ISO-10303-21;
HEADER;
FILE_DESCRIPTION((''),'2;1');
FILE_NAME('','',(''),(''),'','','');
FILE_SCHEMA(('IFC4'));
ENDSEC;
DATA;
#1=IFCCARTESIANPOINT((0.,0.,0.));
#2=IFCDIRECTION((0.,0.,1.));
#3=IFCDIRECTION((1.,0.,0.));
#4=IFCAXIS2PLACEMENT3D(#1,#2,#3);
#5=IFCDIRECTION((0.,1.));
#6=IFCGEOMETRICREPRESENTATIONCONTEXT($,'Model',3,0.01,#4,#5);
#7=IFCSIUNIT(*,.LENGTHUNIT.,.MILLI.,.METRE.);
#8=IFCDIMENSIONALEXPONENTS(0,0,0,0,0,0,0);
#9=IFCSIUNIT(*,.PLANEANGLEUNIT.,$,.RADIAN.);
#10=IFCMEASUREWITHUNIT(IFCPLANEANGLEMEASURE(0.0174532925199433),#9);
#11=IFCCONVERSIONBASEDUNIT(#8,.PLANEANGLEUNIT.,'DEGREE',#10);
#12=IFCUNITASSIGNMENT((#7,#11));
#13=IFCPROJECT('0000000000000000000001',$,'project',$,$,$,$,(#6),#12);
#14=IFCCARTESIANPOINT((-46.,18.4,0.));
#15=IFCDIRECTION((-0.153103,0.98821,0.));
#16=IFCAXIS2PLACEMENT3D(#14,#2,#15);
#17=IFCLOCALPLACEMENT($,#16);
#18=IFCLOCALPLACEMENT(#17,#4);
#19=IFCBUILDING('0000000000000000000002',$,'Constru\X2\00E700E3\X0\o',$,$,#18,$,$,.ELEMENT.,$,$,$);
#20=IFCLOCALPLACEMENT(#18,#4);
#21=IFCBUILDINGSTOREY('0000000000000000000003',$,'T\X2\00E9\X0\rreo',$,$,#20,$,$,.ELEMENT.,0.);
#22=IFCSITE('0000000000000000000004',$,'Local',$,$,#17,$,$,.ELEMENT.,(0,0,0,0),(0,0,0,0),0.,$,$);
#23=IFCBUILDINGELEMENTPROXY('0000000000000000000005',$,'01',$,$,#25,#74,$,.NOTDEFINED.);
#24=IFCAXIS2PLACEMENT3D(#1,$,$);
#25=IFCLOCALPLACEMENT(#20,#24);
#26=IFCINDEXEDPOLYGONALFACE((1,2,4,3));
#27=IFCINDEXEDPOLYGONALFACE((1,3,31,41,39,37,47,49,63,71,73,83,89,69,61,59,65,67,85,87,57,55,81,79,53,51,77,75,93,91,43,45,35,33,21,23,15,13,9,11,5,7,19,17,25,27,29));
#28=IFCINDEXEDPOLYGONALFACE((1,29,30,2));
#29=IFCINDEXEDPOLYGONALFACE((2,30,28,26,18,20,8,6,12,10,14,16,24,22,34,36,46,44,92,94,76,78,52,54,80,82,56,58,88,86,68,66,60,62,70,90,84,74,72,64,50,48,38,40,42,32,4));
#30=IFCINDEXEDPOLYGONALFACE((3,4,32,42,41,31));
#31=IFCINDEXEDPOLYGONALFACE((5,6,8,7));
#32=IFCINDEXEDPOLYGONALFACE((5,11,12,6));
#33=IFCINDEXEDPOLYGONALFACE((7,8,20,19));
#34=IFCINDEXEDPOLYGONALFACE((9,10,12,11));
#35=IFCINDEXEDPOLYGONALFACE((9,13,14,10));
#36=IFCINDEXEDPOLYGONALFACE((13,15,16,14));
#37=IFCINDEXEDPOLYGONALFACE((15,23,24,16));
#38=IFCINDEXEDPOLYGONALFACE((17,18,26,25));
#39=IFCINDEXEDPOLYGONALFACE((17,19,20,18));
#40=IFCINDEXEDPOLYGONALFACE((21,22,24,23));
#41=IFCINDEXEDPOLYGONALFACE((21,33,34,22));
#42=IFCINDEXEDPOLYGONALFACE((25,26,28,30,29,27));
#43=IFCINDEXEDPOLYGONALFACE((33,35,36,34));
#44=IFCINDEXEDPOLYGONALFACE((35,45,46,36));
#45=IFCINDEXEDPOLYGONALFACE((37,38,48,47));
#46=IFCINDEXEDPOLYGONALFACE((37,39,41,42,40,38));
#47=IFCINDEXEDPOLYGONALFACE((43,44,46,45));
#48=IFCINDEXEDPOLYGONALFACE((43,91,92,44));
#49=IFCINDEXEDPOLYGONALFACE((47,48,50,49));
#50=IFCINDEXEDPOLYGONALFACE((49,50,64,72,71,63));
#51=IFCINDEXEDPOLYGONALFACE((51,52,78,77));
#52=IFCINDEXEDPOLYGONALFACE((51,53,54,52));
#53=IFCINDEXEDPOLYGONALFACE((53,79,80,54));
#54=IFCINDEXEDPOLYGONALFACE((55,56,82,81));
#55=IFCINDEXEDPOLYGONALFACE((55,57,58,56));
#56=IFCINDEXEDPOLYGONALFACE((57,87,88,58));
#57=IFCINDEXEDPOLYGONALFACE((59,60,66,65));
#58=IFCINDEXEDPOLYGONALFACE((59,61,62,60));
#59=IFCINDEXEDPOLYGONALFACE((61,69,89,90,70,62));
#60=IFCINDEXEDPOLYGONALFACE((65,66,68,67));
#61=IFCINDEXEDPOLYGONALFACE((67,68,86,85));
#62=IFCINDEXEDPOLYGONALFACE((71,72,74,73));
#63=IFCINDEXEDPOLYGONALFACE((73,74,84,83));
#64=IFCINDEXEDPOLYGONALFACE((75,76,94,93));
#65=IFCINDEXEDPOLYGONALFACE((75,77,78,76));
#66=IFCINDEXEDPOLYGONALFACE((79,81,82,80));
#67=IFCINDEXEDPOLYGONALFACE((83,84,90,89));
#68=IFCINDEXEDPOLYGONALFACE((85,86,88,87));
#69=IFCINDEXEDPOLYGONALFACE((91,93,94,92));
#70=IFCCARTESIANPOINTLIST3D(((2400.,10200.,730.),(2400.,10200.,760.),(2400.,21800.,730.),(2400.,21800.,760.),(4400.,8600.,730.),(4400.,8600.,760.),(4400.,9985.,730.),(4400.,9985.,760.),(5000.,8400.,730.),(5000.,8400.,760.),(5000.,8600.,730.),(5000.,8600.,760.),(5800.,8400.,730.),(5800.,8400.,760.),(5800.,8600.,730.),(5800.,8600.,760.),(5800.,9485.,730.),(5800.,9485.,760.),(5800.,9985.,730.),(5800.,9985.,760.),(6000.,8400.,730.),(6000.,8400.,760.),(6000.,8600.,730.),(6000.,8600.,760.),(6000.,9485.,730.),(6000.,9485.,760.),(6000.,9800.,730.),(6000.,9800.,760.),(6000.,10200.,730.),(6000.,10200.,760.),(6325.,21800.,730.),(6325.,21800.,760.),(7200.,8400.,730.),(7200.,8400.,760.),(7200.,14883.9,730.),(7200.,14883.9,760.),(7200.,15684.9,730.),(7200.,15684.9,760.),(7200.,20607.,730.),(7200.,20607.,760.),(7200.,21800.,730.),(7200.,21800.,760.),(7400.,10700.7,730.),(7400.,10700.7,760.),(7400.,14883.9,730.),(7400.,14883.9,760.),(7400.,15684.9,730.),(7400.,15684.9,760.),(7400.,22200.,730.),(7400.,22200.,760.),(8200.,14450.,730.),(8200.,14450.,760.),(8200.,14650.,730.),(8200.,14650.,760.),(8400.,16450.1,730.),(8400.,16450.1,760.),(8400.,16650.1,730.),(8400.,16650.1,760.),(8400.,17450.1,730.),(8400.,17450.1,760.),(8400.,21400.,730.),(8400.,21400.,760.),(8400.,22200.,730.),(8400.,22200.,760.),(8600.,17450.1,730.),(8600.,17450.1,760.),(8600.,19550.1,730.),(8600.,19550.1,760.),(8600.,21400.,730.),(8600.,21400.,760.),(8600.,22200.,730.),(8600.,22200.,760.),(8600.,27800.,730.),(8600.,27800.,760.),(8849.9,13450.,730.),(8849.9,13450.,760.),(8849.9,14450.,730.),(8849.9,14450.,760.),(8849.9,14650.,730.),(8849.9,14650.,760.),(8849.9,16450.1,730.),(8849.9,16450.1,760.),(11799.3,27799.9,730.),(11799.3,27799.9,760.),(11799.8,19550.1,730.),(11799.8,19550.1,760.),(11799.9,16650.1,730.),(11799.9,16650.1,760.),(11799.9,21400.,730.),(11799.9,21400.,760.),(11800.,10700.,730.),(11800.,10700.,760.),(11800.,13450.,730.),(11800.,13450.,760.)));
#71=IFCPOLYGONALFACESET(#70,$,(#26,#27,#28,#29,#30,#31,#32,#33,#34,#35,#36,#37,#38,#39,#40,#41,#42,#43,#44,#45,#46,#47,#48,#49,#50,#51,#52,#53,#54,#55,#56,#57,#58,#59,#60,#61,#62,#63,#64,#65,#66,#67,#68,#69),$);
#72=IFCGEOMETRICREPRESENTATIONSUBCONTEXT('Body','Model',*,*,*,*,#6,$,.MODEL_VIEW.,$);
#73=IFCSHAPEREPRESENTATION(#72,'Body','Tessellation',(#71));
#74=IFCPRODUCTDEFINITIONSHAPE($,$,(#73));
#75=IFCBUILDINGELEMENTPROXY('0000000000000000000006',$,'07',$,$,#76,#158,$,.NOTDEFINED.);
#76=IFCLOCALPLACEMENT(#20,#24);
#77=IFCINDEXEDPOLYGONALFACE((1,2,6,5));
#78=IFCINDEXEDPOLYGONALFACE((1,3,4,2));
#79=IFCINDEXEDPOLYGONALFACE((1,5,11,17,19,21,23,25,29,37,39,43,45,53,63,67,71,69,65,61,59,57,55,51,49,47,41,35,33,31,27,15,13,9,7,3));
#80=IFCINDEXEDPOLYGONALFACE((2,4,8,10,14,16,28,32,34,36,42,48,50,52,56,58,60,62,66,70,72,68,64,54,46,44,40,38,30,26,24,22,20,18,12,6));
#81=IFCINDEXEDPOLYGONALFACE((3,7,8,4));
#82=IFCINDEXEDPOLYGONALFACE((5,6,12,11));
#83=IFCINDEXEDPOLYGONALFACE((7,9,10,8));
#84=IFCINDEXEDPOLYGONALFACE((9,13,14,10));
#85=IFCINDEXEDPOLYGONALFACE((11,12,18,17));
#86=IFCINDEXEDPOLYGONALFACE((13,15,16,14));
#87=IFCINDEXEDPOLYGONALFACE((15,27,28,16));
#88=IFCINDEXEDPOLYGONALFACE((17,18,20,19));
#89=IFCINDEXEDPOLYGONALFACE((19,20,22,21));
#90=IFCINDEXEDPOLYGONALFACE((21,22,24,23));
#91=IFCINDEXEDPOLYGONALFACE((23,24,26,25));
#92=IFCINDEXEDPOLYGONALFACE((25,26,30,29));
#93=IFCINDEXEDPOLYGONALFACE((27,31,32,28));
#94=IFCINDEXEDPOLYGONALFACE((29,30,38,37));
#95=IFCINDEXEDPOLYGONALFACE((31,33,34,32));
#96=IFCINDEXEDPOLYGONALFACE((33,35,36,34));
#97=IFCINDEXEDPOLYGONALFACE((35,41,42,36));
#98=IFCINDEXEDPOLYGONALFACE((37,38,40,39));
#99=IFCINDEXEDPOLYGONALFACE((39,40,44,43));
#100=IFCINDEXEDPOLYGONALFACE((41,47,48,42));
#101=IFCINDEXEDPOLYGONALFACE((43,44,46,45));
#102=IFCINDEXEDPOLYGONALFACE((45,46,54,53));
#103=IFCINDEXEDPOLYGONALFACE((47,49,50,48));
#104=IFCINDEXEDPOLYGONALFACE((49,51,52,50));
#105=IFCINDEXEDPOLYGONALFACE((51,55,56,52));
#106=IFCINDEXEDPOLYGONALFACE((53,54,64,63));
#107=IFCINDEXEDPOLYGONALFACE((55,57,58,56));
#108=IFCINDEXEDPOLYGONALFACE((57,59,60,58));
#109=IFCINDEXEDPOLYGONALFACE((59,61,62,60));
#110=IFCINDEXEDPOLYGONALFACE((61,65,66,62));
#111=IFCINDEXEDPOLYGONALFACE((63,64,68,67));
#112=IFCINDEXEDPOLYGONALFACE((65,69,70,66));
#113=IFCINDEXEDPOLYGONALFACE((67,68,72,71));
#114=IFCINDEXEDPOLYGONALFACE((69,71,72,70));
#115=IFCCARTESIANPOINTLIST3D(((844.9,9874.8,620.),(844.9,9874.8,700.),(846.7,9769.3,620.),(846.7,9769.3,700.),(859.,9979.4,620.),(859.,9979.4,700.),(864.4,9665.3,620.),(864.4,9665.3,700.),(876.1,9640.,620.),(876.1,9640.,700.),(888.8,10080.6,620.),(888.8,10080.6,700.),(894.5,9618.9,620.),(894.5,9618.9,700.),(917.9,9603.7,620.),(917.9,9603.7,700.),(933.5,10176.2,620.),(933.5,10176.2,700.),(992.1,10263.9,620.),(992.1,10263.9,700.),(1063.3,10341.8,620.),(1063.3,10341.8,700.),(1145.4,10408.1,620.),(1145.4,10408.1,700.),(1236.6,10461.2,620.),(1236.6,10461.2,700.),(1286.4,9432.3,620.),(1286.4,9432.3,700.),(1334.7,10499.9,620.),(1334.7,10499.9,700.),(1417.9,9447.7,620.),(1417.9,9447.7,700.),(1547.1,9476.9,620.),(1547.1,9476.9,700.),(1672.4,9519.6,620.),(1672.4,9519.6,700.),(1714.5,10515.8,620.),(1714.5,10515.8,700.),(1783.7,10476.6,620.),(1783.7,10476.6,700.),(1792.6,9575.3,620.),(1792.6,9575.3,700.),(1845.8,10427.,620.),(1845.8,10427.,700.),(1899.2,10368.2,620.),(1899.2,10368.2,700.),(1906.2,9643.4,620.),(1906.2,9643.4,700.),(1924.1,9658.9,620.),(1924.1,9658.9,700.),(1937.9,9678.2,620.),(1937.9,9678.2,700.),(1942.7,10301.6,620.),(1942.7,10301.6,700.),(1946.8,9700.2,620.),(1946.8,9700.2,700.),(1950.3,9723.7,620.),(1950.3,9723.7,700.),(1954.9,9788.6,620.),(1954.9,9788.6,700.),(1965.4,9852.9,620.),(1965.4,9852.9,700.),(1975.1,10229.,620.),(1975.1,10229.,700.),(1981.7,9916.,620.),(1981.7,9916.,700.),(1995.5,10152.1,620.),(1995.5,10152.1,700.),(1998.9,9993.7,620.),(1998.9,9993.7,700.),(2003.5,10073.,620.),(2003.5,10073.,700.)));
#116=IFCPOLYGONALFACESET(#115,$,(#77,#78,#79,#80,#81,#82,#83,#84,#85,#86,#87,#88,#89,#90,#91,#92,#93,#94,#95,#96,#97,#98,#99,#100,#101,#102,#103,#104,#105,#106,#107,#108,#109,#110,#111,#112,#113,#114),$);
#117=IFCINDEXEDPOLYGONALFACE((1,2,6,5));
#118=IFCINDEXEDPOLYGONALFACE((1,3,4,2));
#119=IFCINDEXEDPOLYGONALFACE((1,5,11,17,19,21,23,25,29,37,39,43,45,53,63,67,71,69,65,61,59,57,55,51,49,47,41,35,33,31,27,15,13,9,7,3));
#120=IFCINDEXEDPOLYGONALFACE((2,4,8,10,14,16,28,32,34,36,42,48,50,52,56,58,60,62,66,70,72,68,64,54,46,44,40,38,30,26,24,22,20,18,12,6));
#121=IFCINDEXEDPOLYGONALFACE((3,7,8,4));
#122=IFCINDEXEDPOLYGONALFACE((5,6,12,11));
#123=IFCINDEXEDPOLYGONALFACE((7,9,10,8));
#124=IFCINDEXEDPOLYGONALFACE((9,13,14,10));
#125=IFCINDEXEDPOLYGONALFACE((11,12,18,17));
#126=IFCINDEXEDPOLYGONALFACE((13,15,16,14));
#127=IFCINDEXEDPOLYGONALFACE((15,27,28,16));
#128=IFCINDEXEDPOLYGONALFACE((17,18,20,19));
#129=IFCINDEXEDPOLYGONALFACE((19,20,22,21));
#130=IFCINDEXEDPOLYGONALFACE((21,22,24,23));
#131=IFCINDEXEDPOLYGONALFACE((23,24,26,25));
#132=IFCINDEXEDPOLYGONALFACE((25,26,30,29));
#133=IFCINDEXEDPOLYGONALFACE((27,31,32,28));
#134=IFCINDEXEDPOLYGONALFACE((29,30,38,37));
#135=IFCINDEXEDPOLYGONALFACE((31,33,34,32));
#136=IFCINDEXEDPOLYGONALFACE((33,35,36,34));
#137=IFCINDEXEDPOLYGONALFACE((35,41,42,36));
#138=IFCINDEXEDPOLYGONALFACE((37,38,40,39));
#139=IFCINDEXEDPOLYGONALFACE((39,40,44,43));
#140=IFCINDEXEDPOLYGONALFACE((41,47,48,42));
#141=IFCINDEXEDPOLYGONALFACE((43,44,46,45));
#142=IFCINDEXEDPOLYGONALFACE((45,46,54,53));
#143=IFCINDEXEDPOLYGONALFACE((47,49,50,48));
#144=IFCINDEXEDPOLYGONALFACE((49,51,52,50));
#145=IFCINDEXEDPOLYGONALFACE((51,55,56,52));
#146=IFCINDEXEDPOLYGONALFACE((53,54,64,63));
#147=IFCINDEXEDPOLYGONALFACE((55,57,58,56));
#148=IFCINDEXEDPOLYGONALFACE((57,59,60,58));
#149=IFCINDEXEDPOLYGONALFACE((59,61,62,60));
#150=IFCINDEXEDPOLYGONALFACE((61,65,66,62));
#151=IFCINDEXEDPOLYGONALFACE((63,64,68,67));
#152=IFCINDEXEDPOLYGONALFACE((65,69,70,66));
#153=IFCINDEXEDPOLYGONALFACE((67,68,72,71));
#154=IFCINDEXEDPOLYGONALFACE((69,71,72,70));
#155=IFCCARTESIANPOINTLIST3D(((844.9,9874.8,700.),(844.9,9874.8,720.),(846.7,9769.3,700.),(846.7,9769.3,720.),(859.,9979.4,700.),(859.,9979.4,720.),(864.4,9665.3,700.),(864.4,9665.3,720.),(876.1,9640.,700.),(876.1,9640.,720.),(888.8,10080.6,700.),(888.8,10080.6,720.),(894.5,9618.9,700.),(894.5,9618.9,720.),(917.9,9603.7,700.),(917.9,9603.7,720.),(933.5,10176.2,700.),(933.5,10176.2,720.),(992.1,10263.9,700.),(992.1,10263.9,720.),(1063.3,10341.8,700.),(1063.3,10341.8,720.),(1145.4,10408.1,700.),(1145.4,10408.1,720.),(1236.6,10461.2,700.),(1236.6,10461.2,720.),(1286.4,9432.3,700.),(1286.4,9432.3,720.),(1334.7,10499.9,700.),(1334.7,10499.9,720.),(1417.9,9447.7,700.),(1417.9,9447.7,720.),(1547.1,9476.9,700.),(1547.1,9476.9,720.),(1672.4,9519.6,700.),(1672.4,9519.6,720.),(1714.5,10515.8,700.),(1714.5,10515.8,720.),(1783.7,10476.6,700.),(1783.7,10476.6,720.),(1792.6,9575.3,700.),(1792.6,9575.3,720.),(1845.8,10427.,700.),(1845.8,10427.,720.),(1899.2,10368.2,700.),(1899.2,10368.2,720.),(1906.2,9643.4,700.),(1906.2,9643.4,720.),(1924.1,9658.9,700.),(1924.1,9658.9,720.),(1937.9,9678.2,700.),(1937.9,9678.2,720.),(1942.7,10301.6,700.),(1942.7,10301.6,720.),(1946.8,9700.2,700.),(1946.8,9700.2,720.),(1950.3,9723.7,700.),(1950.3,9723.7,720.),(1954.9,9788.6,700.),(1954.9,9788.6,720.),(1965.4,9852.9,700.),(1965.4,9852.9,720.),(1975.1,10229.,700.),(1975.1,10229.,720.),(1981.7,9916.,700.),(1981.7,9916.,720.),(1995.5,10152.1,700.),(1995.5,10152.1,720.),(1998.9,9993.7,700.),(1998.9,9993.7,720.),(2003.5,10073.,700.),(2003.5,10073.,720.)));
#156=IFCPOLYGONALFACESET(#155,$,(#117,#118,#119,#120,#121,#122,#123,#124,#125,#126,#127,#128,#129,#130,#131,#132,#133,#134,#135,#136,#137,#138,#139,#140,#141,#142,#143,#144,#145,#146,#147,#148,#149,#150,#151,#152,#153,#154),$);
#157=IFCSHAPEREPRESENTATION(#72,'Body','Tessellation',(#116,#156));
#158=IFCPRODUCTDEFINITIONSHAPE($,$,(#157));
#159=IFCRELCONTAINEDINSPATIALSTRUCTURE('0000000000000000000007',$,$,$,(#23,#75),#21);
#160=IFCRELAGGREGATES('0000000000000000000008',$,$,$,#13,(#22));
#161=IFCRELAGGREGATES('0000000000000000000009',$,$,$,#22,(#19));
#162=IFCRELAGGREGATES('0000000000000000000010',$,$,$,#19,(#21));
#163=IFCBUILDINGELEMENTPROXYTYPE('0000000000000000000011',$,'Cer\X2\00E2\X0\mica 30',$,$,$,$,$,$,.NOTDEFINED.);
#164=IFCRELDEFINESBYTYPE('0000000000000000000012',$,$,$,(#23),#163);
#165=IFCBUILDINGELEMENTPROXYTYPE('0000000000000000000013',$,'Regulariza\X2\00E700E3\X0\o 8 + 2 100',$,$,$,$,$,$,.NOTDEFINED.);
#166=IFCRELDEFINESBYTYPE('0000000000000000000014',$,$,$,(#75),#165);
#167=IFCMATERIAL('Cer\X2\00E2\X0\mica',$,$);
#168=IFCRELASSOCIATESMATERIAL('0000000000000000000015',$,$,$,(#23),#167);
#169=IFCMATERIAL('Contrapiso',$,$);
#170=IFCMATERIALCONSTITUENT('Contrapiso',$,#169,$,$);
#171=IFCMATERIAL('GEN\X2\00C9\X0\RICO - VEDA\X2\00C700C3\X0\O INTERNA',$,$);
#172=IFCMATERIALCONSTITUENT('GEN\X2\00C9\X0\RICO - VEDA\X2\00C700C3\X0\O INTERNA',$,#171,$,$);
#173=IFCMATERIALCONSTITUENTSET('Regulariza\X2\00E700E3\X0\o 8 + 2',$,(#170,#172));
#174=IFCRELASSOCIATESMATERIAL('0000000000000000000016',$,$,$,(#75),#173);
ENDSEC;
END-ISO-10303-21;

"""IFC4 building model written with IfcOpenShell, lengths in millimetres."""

from ifc_helpers import new_model, entity, si_unit, converted_unit, direction, frame, origin_with_axes, place, context, subcontext, project, spatial, line, arc, indexed_curve, outline, extrude, material, constituent, constituent_set, type_object, element, save


model = new_model("IFC4")

# Units and contexts
model_context = context("Model", 3, precision=0.01, world=origin_with_axes(), true_north=direction((0.0, 1.0)))
body_context = subcontext(model_context, "Body", "Model", "MODEL_VIEW")
ifc_project = project(units=[si_unit("LENGTHUNIT", "METRE", prefix="MILLI"), converted_unit("PLANEANGLEUNIT", "DEGREE", entity("IfcPlaneAngleMeasure", 0.0174532925199433), si_unit("PLANEANGLEUNIT", "RADIAN"), dimensions=[0, 0, 0, 0, 0, 0, 0])], contexts=[model_context])

# Site, building, storey
site_placement = place(None, frame((-46.0, 18.4, 0.0), z_axis=(0.0, 0.0, 1.0), x_axis=(-0.153103, 0.98821, 0.0)))
site = spatial("IfcSite", under=ifc_project, at=site_placement, Name="Local", CompositionType="ELEMENT", RefLatitude=(0, 0, 0, 0), RefLongitude=(0, 0, 0, 0), RefElevation=0.0)
building_placement = place(site_placement, origin_with_axes())
building = spatial("IfcBuilding", under=site, at=building_placement, Name="Construção", CompositionType="ELEMENT")
storey_placement = place(building_placement, origin_with_axes())
storey = spatial("IfcBuildingStorey", under=building, at=storey_placement, Name="Térreo", CompositionType="ELEMENT", Elevation=0.0)

# Shared definitions
ifc_material_1 = material(Name="GENÉRICO - VEDAÇÃO INTERNA")

# Building element proxies
ifc_material_2 = material(Name="Cerâmica")
building_element_proxy_type_1 = type_object("IfcBuildingElementProxyType", Name="Cerâmica 30", PredefinedType="NOTDEFINED")
proxy_1_placement = place(storey_placement, frame((2400.0, 10200.0, 760.0), z_axis=(0.0, 0.0, 1.0), x_axis=(1.0, 0.0, 0.0)))
element("IfcBuildingElementProxy", 1, at=proxy_1_placement, inside=storey, type_object=building_element_proxy_type_1, material=ifc_material_2, Name="01", PredefinedType="NOTDEFINED", context=body_context, shape_type="SweptSolid", body=[
    extrude(outline(indexed_curve([(0.0, 0.0), (3600.0, 0.0), (3600.0, -400.0), (3600.0, -715.0), (3400.0, -715.0), (3400.0, -215.0), (2000.0, -215.0), (2000.0, -1600.0), (2600.0, -1600.0), (2600.0, -1800.0), (3400.0, -1800.0), (3400.0, -1600.0), (3600.0, -1600.0), (3600.0, -1800.0), (4800.0, -1800.0), (4800.0, 4683.9), (5000.0, 4683.9), (5000.0, 500.7), (9400.0, 500.0), (9400.0, 3250.0), (6449.9, 3250.0), (6449.9, 4250.0), (5800.0, 4250.0), (5800.0, 4450.0), (6449.9, 4450.0), (6449.9, 6250.0), (6000.0, 6250.0), (6000.0, 6450.0), (9399.9, 6450.0), (9399.8, 9350.0), (6200.0, 9350.0), (6200.0, 7250.0), (6000.0, 7250.0), (6000.0, 11200.0), (6200.0, 11200.0), (9399.9, 11200.0), (9399.3, 17599.9), (6200.0, 17600.0), (6200.0, 12000.0), (6000.0, 12000.0), (5000.0, 12000.0), (5000.0, 5484.9), (4800.0, 5484.9), (4800.0, 10407.0), (4800.0, 11600.0), (3925.0, 11600.0), (0.0, 11600.0)], segments=[line(1, 2, 3, 4, 5, 6, 7, 8, 9, 10, 11, 12, 13, 14, 15, 16, 17, 18, 19, 20, 21, 22, 23, 24, 25, 26, 27, 28, 29, 30, 31, 32, 33, 34, 35, 36, 37, 38, 39, 40, 41, 42, 43, 44, 45, 46, 47, 1)])), frame((0.0, 0.0, -30.0), z_axis=(0.0, 0.0, 1.0), x_axis=(1.0, 0.0, 0.0)), (0.0, 0.0, 1.0), 30.0),
])
ifc_material_3 = material(Name="Contrapiso")
ifc_constituent_1 = constituent(ifc_material_3, Name="Contrapiso")
ifc_constituent_2 = constituent(ifc_material_1, Name="GENÉRICO - VEDAÇÃO INTERNA")
ifc_constituent_set_1 = constituent_set(constituents=[ifc_constituent_1, ifc_constituent_2], Name="Regularização 8 + 2")
building_element_proxy_type_2 = type_object("IfcBuildingElementProxyType", Name="Regularização 8 + 2 100", PredefinedType="NOTDEFINED")
proxy_2_placement = place(storey_placement, frame((1334.7, 10499.9, 720.0), z_axis=(0.0, 0.0, 1.0), x_axis=(1.0, 0.0, 0.0)))
element("IfcBuildingElementProxy", 2, at=proxy_2_placement, inside=storey, type_object=building_element_proxy_type_2, material=ifc_constituent_set_1, Name="07", PredefinedType="NOTDEFINED", context=body_context, shape_type="SweptSolid", body=[
    extrude(outline(indexed_curve([(0.0, 0.0), (-401.2, -323.7), (-470.4, -834.6), (-450.2, -871.1), (-416.8, -896.2), (-48.4, -1067.6), (275.6, -1003.3), (571.4, -856.5), (603.2, -821.7), (615.5, -776.2), (624.7, -679.0), (647.0, -583.9), (625.6, -234.0), (379.7, 15.9)], segments=[arc(1, 2, 3), arc(3, 4, 5), line(5, 6), arc(6, 7, 8), arc(8, 9, 10), arc(10, 11, 12), arc(12, 13, 14), line(14, 1)])), frame((0.0, 0.0, -100.0), z_axis=(0.0, 0.0, 1.0), x_axis=(1.0, 0.0, 0.0)), (0.0, 0.0, 1.0), 80.0),
    extrude(outline(indexed_curve([(0.0, 0.0), (-401.2, -323.7), (-470.4, -834.6), (-450.2, -871.1), (-416.8, -896.2), (-48.4, -1067.6), (275.6, -1003.3), (571.4, -856.5), (603.2, -821.7), (615.5, -776.2), (624.7, -679.0), (647.0, -583.9), (625.6, -234.0), (379.7, 15.9)], segments=[arc(1, 2, 3), arc(3, 4, 5), line(5, 6), arc(6, 7, 8), arc(8, 9, 10), arc(10, 11, 12), arc(12, 13, 14), line(14, 1)])), frame((0.0, 0.0, -20.0), z_axis=(0.0, 0.0, 1.0), x_axis=(1.0, 0.0, 0.0)), (0.0, 0.0, 1.0), 20.0),
])

save(model, "model.ifc")
